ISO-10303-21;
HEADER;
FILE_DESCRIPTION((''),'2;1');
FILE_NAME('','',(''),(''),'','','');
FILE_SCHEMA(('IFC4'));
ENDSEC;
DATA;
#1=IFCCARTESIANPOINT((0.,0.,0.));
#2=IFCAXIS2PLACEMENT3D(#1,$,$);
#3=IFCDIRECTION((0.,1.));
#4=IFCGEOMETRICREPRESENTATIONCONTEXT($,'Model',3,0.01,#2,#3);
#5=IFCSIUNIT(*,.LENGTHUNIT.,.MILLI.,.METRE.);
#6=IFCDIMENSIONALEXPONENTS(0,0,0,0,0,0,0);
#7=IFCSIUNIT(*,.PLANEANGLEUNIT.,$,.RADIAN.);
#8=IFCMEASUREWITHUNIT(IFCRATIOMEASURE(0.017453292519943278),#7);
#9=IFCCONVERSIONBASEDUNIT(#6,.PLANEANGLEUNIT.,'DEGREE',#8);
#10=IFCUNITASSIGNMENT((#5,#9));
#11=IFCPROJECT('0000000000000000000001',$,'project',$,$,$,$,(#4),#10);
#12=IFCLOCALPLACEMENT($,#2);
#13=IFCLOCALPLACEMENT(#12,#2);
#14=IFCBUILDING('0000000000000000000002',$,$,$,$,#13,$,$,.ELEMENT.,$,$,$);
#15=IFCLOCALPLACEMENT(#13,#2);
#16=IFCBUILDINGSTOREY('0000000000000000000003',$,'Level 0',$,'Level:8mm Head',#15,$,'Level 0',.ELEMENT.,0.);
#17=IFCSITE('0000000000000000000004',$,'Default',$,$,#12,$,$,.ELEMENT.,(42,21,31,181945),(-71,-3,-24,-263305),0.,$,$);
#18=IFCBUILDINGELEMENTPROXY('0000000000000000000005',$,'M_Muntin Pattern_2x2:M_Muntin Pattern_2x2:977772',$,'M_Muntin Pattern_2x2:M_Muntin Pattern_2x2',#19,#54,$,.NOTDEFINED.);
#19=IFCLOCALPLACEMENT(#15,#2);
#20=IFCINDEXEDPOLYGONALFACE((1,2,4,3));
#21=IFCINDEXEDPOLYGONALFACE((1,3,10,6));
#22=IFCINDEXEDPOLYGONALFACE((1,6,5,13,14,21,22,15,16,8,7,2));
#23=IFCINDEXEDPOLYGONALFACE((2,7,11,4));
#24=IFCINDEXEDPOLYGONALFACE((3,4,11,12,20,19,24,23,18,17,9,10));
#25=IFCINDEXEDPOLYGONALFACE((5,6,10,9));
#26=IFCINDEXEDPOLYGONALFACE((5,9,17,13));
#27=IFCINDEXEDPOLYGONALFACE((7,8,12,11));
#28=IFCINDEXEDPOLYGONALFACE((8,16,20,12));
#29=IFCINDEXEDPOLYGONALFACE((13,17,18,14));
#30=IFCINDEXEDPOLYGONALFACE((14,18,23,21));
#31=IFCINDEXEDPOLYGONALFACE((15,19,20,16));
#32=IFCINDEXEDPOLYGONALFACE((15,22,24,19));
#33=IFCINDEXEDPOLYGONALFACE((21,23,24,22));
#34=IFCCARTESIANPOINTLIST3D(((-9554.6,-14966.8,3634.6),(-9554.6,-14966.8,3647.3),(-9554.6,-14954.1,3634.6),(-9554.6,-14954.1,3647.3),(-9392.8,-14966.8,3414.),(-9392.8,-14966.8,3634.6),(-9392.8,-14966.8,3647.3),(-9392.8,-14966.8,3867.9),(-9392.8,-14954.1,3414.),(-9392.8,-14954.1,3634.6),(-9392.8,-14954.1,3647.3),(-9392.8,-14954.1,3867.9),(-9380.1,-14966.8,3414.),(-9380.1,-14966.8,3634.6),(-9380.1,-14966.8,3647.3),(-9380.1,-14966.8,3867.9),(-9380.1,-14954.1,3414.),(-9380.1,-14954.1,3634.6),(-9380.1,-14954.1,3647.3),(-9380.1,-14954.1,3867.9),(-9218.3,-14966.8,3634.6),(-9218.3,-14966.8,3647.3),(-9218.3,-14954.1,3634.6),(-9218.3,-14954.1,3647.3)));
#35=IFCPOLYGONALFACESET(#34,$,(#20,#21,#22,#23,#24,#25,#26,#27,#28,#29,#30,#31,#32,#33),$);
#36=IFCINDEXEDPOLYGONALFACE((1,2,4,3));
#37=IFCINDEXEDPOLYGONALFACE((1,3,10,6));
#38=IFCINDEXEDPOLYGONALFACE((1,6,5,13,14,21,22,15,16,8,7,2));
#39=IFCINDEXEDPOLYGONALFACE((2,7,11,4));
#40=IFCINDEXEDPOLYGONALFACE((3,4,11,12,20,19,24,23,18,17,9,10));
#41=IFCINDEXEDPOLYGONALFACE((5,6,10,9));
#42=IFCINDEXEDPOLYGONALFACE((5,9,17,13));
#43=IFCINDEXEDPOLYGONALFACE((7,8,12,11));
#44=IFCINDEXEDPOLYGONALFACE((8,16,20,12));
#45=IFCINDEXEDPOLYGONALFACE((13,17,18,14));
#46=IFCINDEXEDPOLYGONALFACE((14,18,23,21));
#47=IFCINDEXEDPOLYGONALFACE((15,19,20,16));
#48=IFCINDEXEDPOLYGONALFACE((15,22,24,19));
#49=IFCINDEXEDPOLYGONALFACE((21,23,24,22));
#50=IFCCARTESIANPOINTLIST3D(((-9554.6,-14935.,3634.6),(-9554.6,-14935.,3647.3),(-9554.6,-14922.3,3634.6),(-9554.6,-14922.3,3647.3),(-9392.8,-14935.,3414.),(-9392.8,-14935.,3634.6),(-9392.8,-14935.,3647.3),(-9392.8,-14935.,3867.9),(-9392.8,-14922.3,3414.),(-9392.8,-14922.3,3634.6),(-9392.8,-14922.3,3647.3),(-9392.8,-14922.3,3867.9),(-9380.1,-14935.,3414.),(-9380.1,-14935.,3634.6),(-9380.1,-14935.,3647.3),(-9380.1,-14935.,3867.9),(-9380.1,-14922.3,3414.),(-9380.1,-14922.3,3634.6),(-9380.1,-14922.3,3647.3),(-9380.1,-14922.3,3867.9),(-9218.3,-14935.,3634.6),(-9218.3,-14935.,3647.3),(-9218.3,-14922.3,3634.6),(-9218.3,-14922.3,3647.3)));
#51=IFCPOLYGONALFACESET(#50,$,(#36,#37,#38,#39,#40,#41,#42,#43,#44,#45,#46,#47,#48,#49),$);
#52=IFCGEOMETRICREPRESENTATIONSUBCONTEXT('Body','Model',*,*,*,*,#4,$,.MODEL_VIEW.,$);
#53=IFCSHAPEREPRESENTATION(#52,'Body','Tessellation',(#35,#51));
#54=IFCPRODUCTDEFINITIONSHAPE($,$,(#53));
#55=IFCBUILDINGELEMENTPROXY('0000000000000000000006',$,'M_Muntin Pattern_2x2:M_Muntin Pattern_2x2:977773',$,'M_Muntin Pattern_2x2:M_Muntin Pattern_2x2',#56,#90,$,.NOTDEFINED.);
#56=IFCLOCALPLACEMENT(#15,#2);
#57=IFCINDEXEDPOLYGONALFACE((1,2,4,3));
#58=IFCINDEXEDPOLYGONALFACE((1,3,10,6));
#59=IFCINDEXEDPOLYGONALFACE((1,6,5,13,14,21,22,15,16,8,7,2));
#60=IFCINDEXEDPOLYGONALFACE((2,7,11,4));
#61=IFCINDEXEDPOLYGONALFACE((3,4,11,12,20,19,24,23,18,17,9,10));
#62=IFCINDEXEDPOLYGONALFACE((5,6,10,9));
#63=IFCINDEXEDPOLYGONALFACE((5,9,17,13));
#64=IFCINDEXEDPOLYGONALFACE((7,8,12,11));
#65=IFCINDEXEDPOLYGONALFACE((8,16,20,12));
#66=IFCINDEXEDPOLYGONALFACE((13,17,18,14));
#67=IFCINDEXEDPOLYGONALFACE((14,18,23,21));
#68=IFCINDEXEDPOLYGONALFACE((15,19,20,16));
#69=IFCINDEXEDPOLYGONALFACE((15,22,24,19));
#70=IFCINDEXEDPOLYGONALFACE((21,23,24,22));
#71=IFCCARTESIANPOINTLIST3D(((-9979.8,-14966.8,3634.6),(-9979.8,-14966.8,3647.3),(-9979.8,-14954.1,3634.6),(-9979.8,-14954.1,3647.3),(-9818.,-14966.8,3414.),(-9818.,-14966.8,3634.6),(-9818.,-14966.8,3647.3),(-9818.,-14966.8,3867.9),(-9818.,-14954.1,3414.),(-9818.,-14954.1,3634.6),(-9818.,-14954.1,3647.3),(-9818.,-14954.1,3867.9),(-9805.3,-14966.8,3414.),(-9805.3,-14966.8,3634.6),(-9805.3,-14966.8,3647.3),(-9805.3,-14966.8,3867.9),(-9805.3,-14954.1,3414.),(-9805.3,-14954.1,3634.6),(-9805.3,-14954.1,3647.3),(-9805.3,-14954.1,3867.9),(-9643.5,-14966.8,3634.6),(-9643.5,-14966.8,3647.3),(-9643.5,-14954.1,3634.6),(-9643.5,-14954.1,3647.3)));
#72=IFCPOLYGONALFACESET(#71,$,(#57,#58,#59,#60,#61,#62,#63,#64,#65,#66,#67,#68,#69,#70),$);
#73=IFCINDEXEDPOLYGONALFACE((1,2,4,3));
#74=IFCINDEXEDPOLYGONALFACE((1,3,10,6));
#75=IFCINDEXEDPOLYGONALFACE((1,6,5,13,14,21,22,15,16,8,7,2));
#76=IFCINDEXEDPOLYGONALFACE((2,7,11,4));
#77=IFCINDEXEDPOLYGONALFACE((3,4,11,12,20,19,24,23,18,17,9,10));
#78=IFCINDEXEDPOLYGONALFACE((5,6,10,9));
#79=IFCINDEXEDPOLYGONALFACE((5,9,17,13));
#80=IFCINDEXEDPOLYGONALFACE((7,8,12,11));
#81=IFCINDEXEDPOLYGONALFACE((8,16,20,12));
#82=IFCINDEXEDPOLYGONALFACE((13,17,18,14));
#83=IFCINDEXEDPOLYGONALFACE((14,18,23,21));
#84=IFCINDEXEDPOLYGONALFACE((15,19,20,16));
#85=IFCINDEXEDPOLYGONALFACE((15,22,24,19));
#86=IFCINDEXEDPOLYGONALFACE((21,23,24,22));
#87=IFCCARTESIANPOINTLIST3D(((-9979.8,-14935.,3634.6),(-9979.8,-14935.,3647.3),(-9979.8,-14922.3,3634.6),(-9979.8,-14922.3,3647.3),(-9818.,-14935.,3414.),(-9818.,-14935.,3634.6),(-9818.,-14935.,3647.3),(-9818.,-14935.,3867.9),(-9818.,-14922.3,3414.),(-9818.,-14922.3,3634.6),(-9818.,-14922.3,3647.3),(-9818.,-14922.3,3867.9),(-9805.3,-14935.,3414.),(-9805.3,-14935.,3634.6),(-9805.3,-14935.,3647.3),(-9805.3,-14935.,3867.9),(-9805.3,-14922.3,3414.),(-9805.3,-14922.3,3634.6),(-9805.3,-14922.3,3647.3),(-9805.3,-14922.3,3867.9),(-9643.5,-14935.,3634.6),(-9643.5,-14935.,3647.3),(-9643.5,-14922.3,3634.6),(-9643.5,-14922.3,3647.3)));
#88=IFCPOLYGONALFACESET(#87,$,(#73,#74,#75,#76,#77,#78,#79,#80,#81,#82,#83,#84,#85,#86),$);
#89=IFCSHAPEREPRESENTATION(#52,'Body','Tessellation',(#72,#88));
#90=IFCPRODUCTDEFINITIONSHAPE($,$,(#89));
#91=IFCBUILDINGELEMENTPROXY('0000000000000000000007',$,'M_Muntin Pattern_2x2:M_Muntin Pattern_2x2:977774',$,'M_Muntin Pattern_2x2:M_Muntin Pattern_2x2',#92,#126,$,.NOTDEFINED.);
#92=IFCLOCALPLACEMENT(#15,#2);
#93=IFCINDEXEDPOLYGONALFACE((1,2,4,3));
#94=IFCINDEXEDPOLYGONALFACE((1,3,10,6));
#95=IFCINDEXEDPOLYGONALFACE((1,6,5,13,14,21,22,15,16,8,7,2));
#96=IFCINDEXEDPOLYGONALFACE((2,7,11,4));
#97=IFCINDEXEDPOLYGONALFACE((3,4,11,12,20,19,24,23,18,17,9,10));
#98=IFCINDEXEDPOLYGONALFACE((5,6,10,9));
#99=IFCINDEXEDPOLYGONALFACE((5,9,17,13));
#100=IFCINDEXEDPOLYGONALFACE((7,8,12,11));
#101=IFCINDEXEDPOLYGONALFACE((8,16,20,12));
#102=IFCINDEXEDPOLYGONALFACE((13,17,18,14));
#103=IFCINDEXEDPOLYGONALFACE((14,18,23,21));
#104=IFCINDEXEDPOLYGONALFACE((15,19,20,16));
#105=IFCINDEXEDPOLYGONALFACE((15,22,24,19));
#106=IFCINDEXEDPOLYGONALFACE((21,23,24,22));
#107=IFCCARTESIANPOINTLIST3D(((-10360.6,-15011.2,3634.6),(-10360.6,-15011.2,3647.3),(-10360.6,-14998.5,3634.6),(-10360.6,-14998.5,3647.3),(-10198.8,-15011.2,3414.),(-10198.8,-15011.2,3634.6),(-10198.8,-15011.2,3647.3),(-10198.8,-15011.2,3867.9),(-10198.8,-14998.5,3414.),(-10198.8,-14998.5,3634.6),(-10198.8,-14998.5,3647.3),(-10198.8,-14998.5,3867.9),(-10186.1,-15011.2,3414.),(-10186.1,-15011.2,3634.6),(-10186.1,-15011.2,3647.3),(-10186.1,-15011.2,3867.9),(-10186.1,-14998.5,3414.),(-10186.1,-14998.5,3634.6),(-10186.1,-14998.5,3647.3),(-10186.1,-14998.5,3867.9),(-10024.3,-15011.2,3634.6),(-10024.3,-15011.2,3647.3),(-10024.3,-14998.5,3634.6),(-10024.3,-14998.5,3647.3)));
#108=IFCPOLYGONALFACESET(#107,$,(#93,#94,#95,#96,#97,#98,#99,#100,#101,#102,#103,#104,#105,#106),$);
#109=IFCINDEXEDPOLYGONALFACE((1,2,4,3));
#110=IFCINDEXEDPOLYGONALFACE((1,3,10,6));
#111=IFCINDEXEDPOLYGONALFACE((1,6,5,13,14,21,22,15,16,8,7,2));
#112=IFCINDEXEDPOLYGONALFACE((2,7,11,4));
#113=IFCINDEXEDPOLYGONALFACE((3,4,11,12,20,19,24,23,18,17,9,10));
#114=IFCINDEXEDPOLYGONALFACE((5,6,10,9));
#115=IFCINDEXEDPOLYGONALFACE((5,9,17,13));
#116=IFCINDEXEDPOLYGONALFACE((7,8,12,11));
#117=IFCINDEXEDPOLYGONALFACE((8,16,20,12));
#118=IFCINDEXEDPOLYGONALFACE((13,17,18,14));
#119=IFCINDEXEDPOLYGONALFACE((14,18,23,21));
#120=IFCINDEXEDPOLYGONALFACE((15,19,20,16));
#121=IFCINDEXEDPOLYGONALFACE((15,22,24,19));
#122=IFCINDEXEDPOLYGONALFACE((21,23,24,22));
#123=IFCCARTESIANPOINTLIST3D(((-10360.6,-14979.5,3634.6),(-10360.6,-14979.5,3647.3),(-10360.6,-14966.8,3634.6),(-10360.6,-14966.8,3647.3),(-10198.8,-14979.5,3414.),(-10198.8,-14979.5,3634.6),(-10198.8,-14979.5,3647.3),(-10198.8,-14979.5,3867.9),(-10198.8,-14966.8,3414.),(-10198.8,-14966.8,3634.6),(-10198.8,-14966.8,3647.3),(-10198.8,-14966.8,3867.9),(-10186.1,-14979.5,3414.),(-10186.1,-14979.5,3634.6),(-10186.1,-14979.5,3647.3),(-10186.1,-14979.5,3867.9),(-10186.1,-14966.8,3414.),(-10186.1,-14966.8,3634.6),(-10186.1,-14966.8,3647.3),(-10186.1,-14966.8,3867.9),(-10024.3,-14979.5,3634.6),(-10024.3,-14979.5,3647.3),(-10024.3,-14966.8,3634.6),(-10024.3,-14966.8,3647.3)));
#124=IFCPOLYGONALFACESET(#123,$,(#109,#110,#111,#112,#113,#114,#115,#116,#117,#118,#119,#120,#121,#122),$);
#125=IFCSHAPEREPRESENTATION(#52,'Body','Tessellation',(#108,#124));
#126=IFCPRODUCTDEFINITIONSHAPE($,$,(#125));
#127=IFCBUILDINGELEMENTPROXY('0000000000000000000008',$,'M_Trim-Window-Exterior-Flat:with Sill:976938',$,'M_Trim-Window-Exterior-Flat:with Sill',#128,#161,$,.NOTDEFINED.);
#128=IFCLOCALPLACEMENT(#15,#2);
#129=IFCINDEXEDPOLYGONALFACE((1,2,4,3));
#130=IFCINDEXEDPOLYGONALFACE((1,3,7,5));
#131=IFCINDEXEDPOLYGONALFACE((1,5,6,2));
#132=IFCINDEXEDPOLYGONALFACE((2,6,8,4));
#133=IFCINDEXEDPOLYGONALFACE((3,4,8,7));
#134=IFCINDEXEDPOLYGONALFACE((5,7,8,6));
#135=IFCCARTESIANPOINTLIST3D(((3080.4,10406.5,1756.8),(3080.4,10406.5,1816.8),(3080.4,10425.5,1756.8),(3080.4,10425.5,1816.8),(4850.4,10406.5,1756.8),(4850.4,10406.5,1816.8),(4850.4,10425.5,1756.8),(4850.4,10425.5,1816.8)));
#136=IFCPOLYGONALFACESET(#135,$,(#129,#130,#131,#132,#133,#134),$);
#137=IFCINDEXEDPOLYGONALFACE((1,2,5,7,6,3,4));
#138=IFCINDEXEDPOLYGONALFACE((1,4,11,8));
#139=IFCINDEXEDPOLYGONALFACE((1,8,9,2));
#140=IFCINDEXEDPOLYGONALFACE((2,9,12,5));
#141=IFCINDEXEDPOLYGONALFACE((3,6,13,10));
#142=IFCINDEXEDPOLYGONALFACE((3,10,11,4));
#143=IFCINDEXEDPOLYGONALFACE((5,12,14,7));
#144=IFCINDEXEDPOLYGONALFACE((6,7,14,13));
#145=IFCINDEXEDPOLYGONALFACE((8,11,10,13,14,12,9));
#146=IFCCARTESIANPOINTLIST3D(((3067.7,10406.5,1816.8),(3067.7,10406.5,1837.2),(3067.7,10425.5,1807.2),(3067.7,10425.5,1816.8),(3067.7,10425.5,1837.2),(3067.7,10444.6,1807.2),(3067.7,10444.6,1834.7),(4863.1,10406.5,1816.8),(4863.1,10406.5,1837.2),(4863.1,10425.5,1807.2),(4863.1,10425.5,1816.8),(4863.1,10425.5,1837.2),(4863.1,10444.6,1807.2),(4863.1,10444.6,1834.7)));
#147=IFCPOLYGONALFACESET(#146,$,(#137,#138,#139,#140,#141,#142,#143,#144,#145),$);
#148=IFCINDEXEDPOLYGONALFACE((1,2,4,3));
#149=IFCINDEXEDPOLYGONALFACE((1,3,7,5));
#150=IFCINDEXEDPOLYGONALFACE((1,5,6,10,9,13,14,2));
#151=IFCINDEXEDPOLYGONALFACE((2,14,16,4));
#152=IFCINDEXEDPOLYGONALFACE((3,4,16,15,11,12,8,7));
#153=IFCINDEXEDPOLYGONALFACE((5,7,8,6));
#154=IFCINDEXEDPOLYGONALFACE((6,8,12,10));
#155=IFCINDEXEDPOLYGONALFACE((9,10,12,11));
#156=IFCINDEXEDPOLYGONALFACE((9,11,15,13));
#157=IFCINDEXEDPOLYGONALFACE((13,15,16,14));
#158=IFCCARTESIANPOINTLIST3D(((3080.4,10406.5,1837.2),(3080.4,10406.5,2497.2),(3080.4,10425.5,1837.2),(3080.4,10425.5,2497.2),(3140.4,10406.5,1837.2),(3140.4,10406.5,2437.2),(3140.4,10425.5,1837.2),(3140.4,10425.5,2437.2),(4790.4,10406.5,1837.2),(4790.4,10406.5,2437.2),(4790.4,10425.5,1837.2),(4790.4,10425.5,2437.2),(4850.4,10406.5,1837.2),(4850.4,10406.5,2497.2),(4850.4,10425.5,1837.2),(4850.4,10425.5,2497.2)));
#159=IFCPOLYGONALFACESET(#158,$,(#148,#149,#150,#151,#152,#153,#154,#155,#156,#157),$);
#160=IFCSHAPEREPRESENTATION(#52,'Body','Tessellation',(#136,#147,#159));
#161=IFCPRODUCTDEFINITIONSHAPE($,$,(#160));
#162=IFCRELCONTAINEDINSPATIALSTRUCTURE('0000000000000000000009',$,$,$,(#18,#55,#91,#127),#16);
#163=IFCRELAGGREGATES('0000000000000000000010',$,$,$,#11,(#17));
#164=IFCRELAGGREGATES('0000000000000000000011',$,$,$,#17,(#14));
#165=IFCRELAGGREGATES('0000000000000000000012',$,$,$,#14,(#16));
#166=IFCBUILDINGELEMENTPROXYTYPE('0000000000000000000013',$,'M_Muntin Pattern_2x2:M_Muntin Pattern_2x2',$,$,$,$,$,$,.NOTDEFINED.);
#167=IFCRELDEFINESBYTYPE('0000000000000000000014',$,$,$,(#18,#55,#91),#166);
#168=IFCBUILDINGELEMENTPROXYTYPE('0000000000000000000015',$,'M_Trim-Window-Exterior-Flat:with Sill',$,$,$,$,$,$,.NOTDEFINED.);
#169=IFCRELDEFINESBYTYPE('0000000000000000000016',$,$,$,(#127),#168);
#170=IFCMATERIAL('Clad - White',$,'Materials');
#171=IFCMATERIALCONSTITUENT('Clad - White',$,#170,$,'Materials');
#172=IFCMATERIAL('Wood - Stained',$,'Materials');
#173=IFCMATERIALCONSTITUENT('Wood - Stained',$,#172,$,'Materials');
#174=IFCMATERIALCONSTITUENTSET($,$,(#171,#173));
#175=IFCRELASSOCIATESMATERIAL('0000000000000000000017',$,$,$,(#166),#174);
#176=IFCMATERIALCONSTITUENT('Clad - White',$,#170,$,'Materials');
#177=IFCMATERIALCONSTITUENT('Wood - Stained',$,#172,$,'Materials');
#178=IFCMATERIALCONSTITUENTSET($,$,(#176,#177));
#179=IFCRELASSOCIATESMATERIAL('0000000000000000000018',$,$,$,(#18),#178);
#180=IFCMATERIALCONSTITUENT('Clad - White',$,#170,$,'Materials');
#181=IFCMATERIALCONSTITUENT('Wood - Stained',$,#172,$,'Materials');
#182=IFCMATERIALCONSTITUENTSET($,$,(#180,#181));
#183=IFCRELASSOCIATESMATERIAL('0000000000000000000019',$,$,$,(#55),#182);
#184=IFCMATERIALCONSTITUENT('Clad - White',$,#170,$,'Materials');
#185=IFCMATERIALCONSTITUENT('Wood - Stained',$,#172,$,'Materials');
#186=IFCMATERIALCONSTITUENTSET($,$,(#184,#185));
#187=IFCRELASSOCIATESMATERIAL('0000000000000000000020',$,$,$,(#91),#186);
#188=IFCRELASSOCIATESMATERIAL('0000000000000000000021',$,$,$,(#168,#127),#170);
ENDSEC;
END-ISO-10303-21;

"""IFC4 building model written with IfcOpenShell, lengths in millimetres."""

from ifc_helpers import new_model, entity, si_unit, converted_unit, direction, frame, origin, place, context, subcontext, project, spatial, indexed_curve, outline, extrude, source, transform, mapped, material, constituent, constituent_set, type_object, type_shapes, element, save


model = new_model("IFC4")

# Units and contexts
model_context = context("Model", 3, precision=0.01, world=origin(), true_north=direction((0.0, 1.0)))
body_context = subcontext(model_context, "Body", "Model", "MODEL_VIEW")
ifc_project = project(units=[si_unit("LENGTHUNIT", "METRE", prefix="MILLI"), converted_unit("PLANEANGLEUNIT", "DEGREE", entity("IfcRatioMeasure", 0.017453292519943278), si_unit("PLANEANGLEUNIT", "RADIAN"), dimensions=[0, 0, 0, 0, 0, 0, 0])], contexts=[model_context])

# Site, building, storey
site_placement = place(None, origin())
site = spatial("IfcSite", under=ifc_project, at=site_placement, Name="Default", CompositionType="ELEMENT", RefLatitude=(42, 21, 31, 181945), RefLongitude=(-71, -3, -24, -263305), RefElevation=0.0)
building_placement = place(site_placement, origin())
building = spatial("IfcBuilding", under=site, at=building_placement, CompositionType="ELEMENT")
storey_placement = place(building_placement, origin())
storey = spatial("IfcBuildingStorey", under=building, at=storey_placement, Name="Level 0", ObjectType="Level:8mm Head", LongName="Level 0", CompositionType="ELEMENT", Elevation=0.0)

# Building element proxies
ifc_material_1 = material(Name="Clad - White", Category="Materials")
ifc_material_2 = material(Name="Wood - Stained", Category="Materials")
ifc_constituent_1 = constituent(ifc_material_1, Name="Clad - White", Category="Materials")
ifc_constituent_2 = constituent(ifc_material_2, Name="Wood - Stained", Category="Materials")
ifc_constituent_set_1 = constituent_set(constituents=[ifc_constituent_1, ifc_constituent_2])
building_element_proxy_type_1 = type_object("IfcBuildingElementProxyType", Name="M_Muntin Pattern_2x2:M_Muntin Pattern_2x2", PredefinedType="NOTDEFINED", material=ifc_constituent_set_1)
shared_shape_1 = source(origin(), body_context, "Body", "SweptSolid", [
    extrude(outline(indexed_curve([(6.4, -6.4), (227.0, -6.4), (227.0, 6.3), (6.4, 6.3), (6.4, 168.2), (-6.3, 168.2), (-6.3, 6.3), (-227.0, 6.3), (-227.0, -6.4), (-6.3, -6.4), (-6.3, -168.1), (6.4, -168.1), (6.4, -6.4)], self_intersect=False)), frame((0.0, 9.5, 227.0), z_axis=(0.0, 1.0, 0.0), x_axis=(0.0, 0.0, 1.0)), (0.0, 0.0, 1.0), 12.7),
    extrude(outline(indexed_curve([(6.4, -6.4), (227.0, -6.4), (227.0, 6.3), (6.4, 6.3), (6.4, 168.2), (-6.3, 168.2), (-6.3, 6.3), (-227.0, 6.3), (-227.0, -6.4), (-6.3, -6.4), (-6.3, -168.1), (6.4, -168.1), (6.4, -6.4)], self_intersect=False)), frame((0.0, -22.2, 227.0), z_axis=(0.0, 1.0, 0.0), x_axis=(0.0, 0.0, 1.0)), (0.0, 0.0, 1.0), 12.7),
])
type_shapes(building_element_proxy_type_1, [shared_shape_1])
ifc_constituent_3 = constituent(ifc_material_1, Name="Clad - White", Category="Materials")
ifc_constituent_4 = constituent(ifc_material_2, Name="Wood - Stained", Category="Materials")
ifc_constituent_set_2 = constituent_set(constituents=[ifc_constituent_3, ifc_constituent_4])
proxy_1_placement = place(storey_placement, frame((-9386.5, -14944.6, 3414.0), z_axis=(0.0, 0.0, 1.0), x_axis=(-1.0, 0.0, 0.0)))
element("IfcBuildingElementProxy", 1, at=proxy_1_placement, inside=storey, type_object=building_element_proxy_type_1, material=ifc_constituent_set_2, Name="M_Muntin Pattern_2x2:M_Muntin Pattern_2x2:977772", ObjectType="M_Muntin Pattern_2x2:M_Muntin Pattern_2x2", PredefinedType="NOTDEFINED", context=body_context, shape_type="MappedRepresentation", body=[
    mapped(shared_shape_1, transform((0.0, 0.0, 0.0), scale=1.0)),
])
ifc_constituent_5 = constituent(ifc_material_1, Name="Clad - White", Category="Materials")
ifc_constituent_6 = constituent(ifc_material_2, Name="Wood - Stained", Category="Materials")
ifc_constituent_set_3 = constituent_set(constituents=[ifc_constituent_5, ifc_constituent_6])
proxy_2_placement = place(storey_placement, frame((-9811.7, -14944.6, 3414.0), z_axis=(0.0, 0.0, 1.0), x_axis=(-1.0, 0.0, 0.0)))
element("IfcBuildingElementProxy", 2, at=proxy_2_placement, inside=storey, type_object=building_element_proxy_type_1, material=ifc_constituent_set_3, Name="M_Muntin Pattern_2x2:M_Muntin Pattern_2x2:977773", ObjectType="M_Muntin Pattern_2x2:M_Muntin Pattern_2x2", PredefinedType="NOTDEFINED", context=body_context, shape_type="MappedRepresentation", body=[
    mapped(shared_shape_1, transform((0.0, 0.0, 0.0), scale=1.0)),
])
ifc_constituent_7 = constituent(ifc_material_1, Name="Clad - White", Category="Materials")
ifc_constituent_8 = constituent(ifc_material_2, Name="Wood - Stained", Category="Materials")
ifc_constituent_set_4 = constituent_set(constituents=[ifc_constituent_7, ifc_constituent_8])
proxy_3_placement = place(storey_placement, frame((-10192.4, -14989.0, 3414.0), z_axis=(0.0, 0.0, 1.0), x_axis=(-1.0, 0.0, 0.0)))
element("IfcBuildingElementProxy", 3, at=proxy_3_placement, inside=storey, type_object=building_element_proxy_type_1, material=ifc_constituent_set_4, Name="M_Muntin Pattern_2x2:M_Muntin Pattern_2x2:977774", ObjectType="M_Muntin Pattern_2x2:M_Muntin Pattern_2x2", PredefinedType="NOTDEFINED", context=body_context, shape_type="MappedRepresentation", body=[
    mapped(shared_shape_1, transform((0.0, 0.0, 0.0), scale=1.0)),
])
building_element_proxy_type_2 = type_object("IfcBuildingElementProxyType", Name="M_Trim-Window-Exterior-Flat:with Sill", PredefinedType="NOTDEFINED", material=ifc_material_1)
shared_shape_2 = source(origin(), body_context, "Body", "SweptSolid", [
    extrude(outline(indexed_curve([(-885.0, -30.0), (885.0, -30.0), (885.0, 30.0), (-885.0, 30.0), (-885.0, -30.0)], self_intersect=False)), frame((0.0, -650.4, 0.0), z_axis=(0.0, 0.0, 1.0), x_axis=(-1.0, 0.0, 0.0)), (0.0, 0.0, 1.0), 19.0),
    extrude(outline(indexed_curve([(-19.0, -15.2), (0.0, -15.2), (0.0, -5.7), (19.0, -5.7), (19.0, 14.8), (0.0, 14.8), (-19.0, 12.3), (-19.0, -15.2)], self_intersect=False)), frame((-897.7, -614.8, 19.0), z_axis=(1.0, 0.0, 0.0), x_axis=(0.0, 0.0, -1.0)), (0.0, 0.0, 1.0), 1795.4),
    extrude(outline(indexed_curve([(-345.0, -885.0), (315.0, -885.0), (315.0, -825.0), (-285.0, -825.0), (-285.0, 825.0), (315.0, 825.0), (315.0, 885.0), (-345.0, 885.0), (-345.0, -885.0)], self_intersect=False)), frame((0.0, -285.0, 0.0), z_axis=(0.0, 0.0, 1.0), x_axis=(0.0, -1.0, 0.0)), (0.0, 0.0, 1.0), 19.0),
])
type_shapes(building_element_proxy_type_2, [shared_shape_2])
for number, where, z_axis, x_axis, name in (
    (4, (3965.4, 10406.5, 2437.2), (0.0, 1.0, 0.0), (-1.0, 0.0, 0.0), "M_Trim-Window-Exterior-Flat:with Sill:976938"),
):
    element("IfcBuildingElementProxy", number, at=place(storey_placement, frame(where, z_axis=z_axis, x_axis=x_axis)), inside=storey, type_object=building_element_proxy_type_2, material=ifc_material_1, Name=name, ObjectType="M_Trim-Window-Exterior-Flat:with Sill", PredefinedType="NOTDEFINED", context=body_context, shape_type="MappedRepresentation", body=[
        mapped(shared_shape_2, transform((0.0, 0.0, 0.0), scale=1.0)),
    ])

save(model, "model.ifc")
